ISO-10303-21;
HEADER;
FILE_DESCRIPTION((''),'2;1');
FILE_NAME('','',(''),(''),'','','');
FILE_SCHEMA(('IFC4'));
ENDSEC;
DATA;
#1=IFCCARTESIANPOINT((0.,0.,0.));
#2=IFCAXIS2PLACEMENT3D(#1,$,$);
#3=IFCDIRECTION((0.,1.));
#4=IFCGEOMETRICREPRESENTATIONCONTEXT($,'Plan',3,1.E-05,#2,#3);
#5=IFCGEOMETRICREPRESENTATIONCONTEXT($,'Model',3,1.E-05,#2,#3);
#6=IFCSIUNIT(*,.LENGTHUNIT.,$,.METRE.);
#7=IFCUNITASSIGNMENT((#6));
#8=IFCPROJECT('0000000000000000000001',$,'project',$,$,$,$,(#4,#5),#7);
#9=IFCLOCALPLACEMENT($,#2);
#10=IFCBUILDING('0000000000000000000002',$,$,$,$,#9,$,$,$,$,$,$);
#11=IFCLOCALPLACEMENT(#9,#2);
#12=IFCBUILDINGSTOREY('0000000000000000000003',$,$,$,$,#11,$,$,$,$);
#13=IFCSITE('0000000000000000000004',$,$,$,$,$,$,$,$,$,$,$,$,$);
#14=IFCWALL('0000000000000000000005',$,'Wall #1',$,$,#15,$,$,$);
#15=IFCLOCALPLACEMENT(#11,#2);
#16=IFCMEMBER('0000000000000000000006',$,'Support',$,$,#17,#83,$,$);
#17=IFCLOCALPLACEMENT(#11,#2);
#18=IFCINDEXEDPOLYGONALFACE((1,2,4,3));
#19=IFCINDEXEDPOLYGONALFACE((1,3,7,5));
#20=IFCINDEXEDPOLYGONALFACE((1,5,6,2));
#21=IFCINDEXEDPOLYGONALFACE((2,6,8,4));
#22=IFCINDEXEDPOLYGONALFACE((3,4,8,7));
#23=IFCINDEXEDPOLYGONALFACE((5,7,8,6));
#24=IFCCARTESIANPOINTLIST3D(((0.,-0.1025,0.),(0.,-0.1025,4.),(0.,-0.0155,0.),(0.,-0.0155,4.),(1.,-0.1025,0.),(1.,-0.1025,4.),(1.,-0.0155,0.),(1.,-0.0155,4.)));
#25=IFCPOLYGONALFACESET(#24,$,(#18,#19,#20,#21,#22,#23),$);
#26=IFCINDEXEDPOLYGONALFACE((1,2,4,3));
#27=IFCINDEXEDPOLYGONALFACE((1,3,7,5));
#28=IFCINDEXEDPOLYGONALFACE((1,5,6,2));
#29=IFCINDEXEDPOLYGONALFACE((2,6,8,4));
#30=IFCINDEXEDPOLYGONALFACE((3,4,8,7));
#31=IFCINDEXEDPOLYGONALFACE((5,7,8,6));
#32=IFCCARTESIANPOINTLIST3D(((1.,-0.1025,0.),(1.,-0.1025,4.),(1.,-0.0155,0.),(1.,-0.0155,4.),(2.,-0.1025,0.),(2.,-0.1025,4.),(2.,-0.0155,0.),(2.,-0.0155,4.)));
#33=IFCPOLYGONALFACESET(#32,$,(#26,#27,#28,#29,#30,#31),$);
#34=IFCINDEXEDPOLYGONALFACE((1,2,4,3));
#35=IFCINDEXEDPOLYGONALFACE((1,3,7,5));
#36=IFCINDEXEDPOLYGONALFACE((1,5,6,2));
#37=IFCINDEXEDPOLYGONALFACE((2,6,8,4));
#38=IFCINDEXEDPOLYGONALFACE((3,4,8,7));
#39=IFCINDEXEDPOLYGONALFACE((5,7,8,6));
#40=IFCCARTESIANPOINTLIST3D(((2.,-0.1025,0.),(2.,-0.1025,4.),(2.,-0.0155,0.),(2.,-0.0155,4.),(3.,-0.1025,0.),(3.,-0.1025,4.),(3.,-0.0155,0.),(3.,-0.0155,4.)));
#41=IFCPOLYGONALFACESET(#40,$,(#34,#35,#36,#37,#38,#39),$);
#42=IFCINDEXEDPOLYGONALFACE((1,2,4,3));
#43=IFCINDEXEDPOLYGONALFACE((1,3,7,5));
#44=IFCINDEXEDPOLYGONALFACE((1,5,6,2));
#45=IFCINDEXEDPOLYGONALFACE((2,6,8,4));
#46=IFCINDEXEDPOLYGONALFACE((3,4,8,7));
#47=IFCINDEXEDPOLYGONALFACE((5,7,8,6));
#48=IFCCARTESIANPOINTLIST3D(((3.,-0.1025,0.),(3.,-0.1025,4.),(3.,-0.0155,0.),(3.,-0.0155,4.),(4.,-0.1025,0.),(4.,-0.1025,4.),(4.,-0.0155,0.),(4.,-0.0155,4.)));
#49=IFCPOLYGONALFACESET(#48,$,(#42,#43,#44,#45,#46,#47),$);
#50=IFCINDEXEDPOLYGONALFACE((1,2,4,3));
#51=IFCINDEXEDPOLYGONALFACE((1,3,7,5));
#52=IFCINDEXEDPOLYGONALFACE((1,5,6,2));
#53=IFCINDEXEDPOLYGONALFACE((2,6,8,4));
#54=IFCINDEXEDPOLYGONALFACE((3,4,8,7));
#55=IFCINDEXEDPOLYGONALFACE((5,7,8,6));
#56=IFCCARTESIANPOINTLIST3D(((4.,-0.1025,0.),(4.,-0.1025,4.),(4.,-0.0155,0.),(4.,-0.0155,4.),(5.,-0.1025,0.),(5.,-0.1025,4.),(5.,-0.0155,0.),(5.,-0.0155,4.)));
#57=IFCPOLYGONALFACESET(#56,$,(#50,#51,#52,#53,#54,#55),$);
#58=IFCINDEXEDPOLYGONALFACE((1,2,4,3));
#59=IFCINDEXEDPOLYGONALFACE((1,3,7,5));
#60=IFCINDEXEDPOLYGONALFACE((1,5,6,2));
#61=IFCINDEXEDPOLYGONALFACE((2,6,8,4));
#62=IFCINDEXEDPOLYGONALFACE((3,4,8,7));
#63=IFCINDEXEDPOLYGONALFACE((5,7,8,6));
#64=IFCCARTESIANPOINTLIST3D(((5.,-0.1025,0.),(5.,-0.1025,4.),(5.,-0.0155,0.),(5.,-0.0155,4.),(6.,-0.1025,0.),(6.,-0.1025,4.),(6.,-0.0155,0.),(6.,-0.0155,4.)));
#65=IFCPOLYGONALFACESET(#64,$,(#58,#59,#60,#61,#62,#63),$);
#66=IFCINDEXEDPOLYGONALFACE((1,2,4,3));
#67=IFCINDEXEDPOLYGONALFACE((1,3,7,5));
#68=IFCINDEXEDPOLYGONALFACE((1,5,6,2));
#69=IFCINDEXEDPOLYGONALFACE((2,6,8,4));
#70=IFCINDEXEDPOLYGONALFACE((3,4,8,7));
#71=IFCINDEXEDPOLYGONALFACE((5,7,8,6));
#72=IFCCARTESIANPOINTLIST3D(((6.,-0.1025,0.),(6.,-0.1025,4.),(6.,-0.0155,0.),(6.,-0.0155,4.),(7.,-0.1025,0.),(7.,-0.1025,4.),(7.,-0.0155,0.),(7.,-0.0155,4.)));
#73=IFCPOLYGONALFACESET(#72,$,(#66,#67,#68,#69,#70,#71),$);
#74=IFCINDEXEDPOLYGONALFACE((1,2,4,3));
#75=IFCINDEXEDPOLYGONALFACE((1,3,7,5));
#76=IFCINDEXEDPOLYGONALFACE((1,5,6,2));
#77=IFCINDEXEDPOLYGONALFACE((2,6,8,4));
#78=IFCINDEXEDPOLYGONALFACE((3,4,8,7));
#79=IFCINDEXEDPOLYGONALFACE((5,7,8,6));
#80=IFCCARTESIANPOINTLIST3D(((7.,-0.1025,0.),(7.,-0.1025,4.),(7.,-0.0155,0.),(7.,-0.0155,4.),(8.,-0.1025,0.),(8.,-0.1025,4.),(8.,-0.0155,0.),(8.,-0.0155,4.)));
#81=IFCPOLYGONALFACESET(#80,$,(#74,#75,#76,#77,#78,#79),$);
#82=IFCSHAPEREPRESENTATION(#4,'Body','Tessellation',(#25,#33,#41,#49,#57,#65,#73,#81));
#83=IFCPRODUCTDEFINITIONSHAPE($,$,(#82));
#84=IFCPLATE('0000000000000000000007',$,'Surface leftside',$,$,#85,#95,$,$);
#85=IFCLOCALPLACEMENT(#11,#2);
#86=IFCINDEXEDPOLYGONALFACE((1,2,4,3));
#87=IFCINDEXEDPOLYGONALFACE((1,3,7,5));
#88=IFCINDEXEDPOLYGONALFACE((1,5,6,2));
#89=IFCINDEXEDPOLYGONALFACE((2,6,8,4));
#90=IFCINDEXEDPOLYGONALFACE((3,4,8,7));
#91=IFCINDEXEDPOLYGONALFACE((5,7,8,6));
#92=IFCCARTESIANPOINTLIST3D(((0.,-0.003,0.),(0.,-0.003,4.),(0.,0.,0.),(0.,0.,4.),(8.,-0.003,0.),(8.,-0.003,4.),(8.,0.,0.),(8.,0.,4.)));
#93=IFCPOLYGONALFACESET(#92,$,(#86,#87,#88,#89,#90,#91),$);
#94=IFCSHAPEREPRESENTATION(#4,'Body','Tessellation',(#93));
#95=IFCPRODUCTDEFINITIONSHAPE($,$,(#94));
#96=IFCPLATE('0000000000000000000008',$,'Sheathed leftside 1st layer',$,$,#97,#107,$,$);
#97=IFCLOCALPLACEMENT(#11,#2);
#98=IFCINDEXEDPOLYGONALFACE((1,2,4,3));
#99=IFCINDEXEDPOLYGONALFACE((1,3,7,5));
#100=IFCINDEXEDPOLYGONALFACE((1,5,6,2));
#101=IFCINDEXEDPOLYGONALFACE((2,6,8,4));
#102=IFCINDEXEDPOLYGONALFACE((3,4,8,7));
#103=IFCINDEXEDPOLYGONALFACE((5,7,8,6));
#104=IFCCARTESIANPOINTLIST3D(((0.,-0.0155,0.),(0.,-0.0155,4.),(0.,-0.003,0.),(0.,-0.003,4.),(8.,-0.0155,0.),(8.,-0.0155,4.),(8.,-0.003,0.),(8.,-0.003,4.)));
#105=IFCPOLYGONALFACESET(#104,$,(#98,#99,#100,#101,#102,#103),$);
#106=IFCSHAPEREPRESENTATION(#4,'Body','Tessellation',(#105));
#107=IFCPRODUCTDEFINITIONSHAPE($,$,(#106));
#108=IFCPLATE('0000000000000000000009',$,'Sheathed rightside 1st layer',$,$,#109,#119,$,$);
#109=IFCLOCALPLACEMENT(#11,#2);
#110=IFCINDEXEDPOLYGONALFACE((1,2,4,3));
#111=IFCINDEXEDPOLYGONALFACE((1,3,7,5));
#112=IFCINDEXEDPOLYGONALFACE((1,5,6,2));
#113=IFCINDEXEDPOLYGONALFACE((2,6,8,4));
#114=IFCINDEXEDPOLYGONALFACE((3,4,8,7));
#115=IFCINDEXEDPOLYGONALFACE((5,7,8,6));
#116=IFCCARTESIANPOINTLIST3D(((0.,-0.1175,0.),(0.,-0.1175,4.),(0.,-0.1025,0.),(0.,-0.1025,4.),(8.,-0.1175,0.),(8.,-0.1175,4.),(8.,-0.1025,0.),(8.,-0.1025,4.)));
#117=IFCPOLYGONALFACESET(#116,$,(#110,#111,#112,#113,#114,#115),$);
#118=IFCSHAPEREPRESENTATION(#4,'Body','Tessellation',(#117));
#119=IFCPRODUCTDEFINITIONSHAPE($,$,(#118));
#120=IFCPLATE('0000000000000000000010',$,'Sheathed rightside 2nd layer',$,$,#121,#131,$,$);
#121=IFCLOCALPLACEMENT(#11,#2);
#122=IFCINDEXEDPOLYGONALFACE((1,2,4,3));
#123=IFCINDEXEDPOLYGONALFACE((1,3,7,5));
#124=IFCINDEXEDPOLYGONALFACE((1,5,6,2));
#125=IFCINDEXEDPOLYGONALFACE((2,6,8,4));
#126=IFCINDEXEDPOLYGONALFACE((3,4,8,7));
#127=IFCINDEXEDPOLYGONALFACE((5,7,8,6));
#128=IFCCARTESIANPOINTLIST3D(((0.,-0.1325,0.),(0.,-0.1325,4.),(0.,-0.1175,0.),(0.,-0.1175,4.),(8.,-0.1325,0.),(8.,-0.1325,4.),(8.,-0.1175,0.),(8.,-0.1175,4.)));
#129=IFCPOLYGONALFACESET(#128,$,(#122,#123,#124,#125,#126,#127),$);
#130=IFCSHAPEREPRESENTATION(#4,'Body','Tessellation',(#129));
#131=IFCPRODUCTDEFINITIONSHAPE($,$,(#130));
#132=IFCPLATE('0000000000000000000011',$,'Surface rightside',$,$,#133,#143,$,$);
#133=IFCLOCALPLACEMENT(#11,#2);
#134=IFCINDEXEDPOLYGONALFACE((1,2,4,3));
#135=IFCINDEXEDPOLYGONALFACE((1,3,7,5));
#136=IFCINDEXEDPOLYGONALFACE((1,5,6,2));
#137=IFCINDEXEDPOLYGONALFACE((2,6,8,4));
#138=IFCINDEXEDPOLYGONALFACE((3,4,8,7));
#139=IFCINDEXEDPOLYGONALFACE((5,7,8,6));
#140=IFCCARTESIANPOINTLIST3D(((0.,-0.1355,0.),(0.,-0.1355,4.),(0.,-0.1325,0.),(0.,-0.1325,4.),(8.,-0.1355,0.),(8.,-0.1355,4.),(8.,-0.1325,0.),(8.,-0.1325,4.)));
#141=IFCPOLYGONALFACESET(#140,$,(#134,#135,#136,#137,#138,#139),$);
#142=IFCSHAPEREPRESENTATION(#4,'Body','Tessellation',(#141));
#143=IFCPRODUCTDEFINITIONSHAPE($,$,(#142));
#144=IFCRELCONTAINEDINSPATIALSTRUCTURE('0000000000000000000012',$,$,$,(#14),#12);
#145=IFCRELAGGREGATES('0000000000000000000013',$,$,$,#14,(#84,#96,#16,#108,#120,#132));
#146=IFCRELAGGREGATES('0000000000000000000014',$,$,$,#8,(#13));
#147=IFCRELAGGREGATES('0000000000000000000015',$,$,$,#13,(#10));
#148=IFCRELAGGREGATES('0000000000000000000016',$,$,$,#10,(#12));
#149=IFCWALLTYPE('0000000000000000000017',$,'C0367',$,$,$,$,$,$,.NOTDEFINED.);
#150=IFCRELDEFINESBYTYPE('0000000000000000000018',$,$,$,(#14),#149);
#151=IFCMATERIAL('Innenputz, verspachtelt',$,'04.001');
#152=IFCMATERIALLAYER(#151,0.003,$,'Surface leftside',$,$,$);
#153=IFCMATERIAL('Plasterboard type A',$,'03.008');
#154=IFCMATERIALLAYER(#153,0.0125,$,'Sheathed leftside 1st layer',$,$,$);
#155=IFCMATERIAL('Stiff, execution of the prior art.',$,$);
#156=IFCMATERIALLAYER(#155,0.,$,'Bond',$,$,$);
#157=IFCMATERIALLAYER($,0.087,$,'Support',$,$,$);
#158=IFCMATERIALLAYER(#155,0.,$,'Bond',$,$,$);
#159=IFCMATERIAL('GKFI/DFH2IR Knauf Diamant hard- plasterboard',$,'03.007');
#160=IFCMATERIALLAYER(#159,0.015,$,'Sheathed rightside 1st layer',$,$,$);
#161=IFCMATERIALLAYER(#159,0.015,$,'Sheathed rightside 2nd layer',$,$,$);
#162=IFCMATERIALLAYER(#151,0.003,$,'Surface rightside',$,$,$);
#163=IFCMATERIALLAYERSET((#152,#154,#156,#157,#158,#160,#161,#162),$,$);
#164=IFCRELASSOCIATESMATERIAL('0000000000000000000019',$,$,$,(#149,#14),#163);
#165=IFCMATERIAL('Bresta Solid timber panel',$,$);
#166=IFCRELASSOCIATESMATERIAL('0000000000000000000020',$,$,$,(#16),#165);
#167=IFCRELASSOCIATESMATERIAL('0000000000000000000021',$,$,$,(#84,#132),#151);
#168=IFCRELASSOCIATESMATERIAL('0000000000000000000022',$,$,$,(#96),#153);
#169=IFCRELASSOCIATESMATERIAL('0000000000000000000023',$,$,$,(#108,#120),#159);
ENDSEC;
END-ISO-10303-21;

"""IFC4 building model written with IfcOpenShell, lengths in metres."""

from ifc_helpers import new_model, si_unit, direction, frame, frame_2d, origin, origin_with_axes, place, context, project, spatial, rectangle, extrude, material, layer, layer_set, type_object, element, aggregate, save


model = new_model("IFC4")

# Units and contexts
plan_context = context("Plan", 3, precision=1e-05, world=origin(), true_north=direction((0.0, 1.0)))
model_context = context("Model", 3, precision=1e-05, world=origin(), true_north=direction((0.0, 1.0)))
ifc_project = project(units=[si_unit("LENGTHUNIT", "METRE")], contexts=[plan_context, model_context])

# Site, building, storey
site = spatial("IfcSite", under=ifc_project)
building_placement = place(None, origin())
building = spatial("IfcBuilding", under=site, at=building_placement)
storey_placement = place(building_placement, origin())
storey = spatial("IfcBuildingStorey", under=building, at=storey_placement)

# Wall, member, plates
ifc_material_1 = material(Name="Innenputz, verspachtelt", Category="04.001")
ifc_layer_1 = layer(ifc_material_1, 0.003, Name="Surface leftside")
ifc_material_2 = material(Name="Plasterboard type A", Category="03.008")
ifc_layer_2 = layer(ifc_material_2, 0.0125, Name="Sheathed leftside 1st layer")
ifc_material_3 = material(Name="Stiff, execution of the prior art.")
ifc_layer_3 = layer(ifc_material_3, 0.0, Name="Bond")
ifc_layer_4 = layer(None, 0.087, Name="Support")
ifc_layer_5 = layer(ifc_material_3, 0.0, Name="Bond")
ifc_material_4 = material(Name="GKFI/DFH2IR Knauf Diamant hard- plasterboard", Category="03.007")
ifc_layer_6 = layer(ifc_material_4, 0.015, Name="Sheathed rightside 1st layer")
ifc_layer_7 = layer(ifc_material_4, 0.015, Name="Sheathed rightside 2nd layer")
ifc_layer_8 = layer(ifc_material_1, 0.003, Name="Surface rightside")
ifc_layer_set = layer_set([ifc_layer_1, ifc_layer_2, ifc_layer_3, ifc_layer_4, ifc_layer_5, ifc_layer_6, ifc_layer_7, ifc_layer_8])
wall_type = type_object("IfcWallType", Name="C0367", PredefinedType="NOTDEFINED", material=ifc_layer_set)
wall_placement = place(None, frame((0.0, 0.0, 0.0), z_axis=(0.0, -1.0, 0.0), x_axis=(1.0, 0.0, 0.0)))
wall = element("IfcWall", 1, at=wall_placement, inside=storey, type_object=wall_type, material=ifc_layer_set, Name="Wall #1")
ifc_material_5 = material(Name="Bresta Solid timber panel")
member_placement = place(wall_placement, origin())
member = element("IfcMember", 2, at=member_placement, material=ifc_material_5, Name="Support", context=plan_context, shape_type="SweptSolid", body=[
    extrude(rectangle(XDim=1.0, YDim=0.087, at=frame_2d((0.5, 0.0435), x_axis=(1.0, 0.0))), frame((0.0, 4.0, 0.0155), z_axis=(0.0, -1.0, 0.0), x_axis=(1.0, 0.0, 0.0)), (0.0, 0.0, 1.0), 4.0),
    extrude(rectangle(XDim=1.0, YDim=0.087, at=frame_2d((0.5, 0.0435), x_axis=(1.0, 0.0))), frame((1.0, 4.0, 0.0155), z_axis=(0.0, -1.0, 0.0), x_axis=(1.0, 0.0, 0.0)), (0.0, 0.0, 1.0), 4.0),
    extrude(rectangle(XDim=1.0, YDim=0.087, at=frame_2d((0.5, 0.0435), x_axis=(1.0, 0.0))), frame((2.0, 4.0, 0.0155), z_axis=(0.0, -1.0, 0.0), x_axis=(1.0, 0.0, 0.0)), (0.0, 0.0, 1.0), 4.0),
    extrude(rectangle(XDim=1.0, YDim=0.087, at=frame_2d((0.5, 0.0435), x_axis=(1.0, 0.0))), frame((3.0, 4.0, 0.0155), z_axis=(0.0, -1.0, 0.0), x_axis=(1.0, 0.0, 0.0)), (0.0, 0.0, 1.0), 4.0),
    extrude(rectangle(XDim=1.0, YDim=0.087, at=frame_2d((0.5, 0.0435), x_axis=(1.0, 0.0))), frame((4.0, 4.0, 0.0155), z_axis=(0.0, -1.0, 0.0), x_axis=(1.0, 0.0, 0.0)), (0.0, 0.0, 1.0), 4.0),
    extrude(rectangle(XDim=1.0, YDim=0.087, at=frame_2d((0.5, 0.0435), x_axis=(1.0, 0.0))), frame((5.0, 4.0, 0.0155), z_axis=(0.0, -1.0, 0.0), x_axis=(1.0, 0.0, 0.0)), (0.0, 0.0, 1.0), 4.0),
    extrude(rectangle(XDim=1.0, YDim=0.087, at=frame_2d((0.5, 0.0435), x_axis=(1.0, 0.0))), frame((6.0, 4.0, 0.0155), z_axis=(0.0, -1.0, 0.0), x_axis=(1.0, 0.0, 0.0)), (0.0, 0.0, 1.0), 4.0),
    extrude(rectangle(XDim=1.0, YDim=0.087, at=frame_2d((0.5, 0.0435), x_axis=(1.0, 0.0))), frame((7.0, 4.0, 0.0155), z_axis=(0.0, -1.0, 0.0), x_axis=(1.0, 0.0, 0.0)), (0.0, 0.0, 1.0), 4.0),
])
plate_1_placement = place(wall_placement, origin())
plate_1 = element("IfcPlate", 3, at=plate_1_placement, material=ifc_material_1, Name="Surface leftside", context=plan_context, shape_type="SweptSolid", body=[
    extrude(rectangle(XDim=8.0, YDim=4.0, at=frame_2d((4.0, 2.0), x_axis=(1.0, 0.0))), origin_with_axes(), (0.0, 0.0, 1.0), 0.003),
])
plate_2_placement = place(wall_placement, origin())
plate_2 = element("IfcPlate", 4, at=plate_2_placement, material=ifc_material_2, Name="Sheathed leftside 1st layer", context=plan_context, shape_type="SweptSolid", body=[
    extrude(rectangle(XDim=8.0, YDim=4.0, at=frame_2d((4.0, 2.0), x_axis=(1.0, 0.0))), frame((0.0, 0.0, 0.003), z_axis=(0.0, 0.0, 1.0), x_axis=(1.0, 0.0, 0.0)), (0.0, 0.0, 1.0), 0.0125),
])
plate_3_placement = place(wall_placement, origin())
plate_3 = element("IfcPlate", 5, at=plate_3_placement, material=ifc_material_4, Name="Sheathed rightside 1st layer", context=plan_context, shape_type="SweptSolid", body=[
    extrude(rectangle(XDim=8.0, YDim=4.0, at=frame_2d((4.0, 2.0), x_axis=(1.0, 0.0))), frame((0.0, 0.0, 0.1025), z_axis=(0.0, 0.0, 1.0), x_axis=(1.0, 0.0, 0.0)), (0.0, 0.0, 1.0), 0.015),
])
plate_4_placement = place(wall_placement, origin())
plate_4 = element("IfcPlate", 6, at=plate_4_placement, material=ifc_material_4, Name="Sheathed rightside 2nd layer", context=plan_context, shape_type="SweptSolid", body=[
    extrude(rectangle(XDim=8.0, YDim=4.0, at=frame_2d((4.0, 2.0), x_axis=(1.0, 0.0))), frame((0.0, 0.0, 0.1175), z_axis=(0.0, 0.0, 1.0), x_axis=(1.0, 0.0, 0.0)), (0.0, 0.0, 1.0), 0.015),
])
plate_5_placement = place(wall_placement, origin())
plate_5 = element("IfcPlate", 7, at=plate_5_placement, material=ifc_material_1, Name="Surface rightside", context=plan_context, shape_type="SweptSolid", body=[
    extrude(rectangle(XDim=8.0, YDim=4.0, at=frame_2d((4.0, 2.0), x_axis=(1.0, 0.0))), frame((0.0, 0.0, 0.1325), z_axis=(0.0, 0.0, 1.0), x_axis=(1.0, 0.0, 0.0)), (0.0, 0.0, 1.0), 0.003),
])
aggregate(wall, [plate_1, plate_2, member, plate_3, plate_4, plate_5])

save(model, "model.ifc")
